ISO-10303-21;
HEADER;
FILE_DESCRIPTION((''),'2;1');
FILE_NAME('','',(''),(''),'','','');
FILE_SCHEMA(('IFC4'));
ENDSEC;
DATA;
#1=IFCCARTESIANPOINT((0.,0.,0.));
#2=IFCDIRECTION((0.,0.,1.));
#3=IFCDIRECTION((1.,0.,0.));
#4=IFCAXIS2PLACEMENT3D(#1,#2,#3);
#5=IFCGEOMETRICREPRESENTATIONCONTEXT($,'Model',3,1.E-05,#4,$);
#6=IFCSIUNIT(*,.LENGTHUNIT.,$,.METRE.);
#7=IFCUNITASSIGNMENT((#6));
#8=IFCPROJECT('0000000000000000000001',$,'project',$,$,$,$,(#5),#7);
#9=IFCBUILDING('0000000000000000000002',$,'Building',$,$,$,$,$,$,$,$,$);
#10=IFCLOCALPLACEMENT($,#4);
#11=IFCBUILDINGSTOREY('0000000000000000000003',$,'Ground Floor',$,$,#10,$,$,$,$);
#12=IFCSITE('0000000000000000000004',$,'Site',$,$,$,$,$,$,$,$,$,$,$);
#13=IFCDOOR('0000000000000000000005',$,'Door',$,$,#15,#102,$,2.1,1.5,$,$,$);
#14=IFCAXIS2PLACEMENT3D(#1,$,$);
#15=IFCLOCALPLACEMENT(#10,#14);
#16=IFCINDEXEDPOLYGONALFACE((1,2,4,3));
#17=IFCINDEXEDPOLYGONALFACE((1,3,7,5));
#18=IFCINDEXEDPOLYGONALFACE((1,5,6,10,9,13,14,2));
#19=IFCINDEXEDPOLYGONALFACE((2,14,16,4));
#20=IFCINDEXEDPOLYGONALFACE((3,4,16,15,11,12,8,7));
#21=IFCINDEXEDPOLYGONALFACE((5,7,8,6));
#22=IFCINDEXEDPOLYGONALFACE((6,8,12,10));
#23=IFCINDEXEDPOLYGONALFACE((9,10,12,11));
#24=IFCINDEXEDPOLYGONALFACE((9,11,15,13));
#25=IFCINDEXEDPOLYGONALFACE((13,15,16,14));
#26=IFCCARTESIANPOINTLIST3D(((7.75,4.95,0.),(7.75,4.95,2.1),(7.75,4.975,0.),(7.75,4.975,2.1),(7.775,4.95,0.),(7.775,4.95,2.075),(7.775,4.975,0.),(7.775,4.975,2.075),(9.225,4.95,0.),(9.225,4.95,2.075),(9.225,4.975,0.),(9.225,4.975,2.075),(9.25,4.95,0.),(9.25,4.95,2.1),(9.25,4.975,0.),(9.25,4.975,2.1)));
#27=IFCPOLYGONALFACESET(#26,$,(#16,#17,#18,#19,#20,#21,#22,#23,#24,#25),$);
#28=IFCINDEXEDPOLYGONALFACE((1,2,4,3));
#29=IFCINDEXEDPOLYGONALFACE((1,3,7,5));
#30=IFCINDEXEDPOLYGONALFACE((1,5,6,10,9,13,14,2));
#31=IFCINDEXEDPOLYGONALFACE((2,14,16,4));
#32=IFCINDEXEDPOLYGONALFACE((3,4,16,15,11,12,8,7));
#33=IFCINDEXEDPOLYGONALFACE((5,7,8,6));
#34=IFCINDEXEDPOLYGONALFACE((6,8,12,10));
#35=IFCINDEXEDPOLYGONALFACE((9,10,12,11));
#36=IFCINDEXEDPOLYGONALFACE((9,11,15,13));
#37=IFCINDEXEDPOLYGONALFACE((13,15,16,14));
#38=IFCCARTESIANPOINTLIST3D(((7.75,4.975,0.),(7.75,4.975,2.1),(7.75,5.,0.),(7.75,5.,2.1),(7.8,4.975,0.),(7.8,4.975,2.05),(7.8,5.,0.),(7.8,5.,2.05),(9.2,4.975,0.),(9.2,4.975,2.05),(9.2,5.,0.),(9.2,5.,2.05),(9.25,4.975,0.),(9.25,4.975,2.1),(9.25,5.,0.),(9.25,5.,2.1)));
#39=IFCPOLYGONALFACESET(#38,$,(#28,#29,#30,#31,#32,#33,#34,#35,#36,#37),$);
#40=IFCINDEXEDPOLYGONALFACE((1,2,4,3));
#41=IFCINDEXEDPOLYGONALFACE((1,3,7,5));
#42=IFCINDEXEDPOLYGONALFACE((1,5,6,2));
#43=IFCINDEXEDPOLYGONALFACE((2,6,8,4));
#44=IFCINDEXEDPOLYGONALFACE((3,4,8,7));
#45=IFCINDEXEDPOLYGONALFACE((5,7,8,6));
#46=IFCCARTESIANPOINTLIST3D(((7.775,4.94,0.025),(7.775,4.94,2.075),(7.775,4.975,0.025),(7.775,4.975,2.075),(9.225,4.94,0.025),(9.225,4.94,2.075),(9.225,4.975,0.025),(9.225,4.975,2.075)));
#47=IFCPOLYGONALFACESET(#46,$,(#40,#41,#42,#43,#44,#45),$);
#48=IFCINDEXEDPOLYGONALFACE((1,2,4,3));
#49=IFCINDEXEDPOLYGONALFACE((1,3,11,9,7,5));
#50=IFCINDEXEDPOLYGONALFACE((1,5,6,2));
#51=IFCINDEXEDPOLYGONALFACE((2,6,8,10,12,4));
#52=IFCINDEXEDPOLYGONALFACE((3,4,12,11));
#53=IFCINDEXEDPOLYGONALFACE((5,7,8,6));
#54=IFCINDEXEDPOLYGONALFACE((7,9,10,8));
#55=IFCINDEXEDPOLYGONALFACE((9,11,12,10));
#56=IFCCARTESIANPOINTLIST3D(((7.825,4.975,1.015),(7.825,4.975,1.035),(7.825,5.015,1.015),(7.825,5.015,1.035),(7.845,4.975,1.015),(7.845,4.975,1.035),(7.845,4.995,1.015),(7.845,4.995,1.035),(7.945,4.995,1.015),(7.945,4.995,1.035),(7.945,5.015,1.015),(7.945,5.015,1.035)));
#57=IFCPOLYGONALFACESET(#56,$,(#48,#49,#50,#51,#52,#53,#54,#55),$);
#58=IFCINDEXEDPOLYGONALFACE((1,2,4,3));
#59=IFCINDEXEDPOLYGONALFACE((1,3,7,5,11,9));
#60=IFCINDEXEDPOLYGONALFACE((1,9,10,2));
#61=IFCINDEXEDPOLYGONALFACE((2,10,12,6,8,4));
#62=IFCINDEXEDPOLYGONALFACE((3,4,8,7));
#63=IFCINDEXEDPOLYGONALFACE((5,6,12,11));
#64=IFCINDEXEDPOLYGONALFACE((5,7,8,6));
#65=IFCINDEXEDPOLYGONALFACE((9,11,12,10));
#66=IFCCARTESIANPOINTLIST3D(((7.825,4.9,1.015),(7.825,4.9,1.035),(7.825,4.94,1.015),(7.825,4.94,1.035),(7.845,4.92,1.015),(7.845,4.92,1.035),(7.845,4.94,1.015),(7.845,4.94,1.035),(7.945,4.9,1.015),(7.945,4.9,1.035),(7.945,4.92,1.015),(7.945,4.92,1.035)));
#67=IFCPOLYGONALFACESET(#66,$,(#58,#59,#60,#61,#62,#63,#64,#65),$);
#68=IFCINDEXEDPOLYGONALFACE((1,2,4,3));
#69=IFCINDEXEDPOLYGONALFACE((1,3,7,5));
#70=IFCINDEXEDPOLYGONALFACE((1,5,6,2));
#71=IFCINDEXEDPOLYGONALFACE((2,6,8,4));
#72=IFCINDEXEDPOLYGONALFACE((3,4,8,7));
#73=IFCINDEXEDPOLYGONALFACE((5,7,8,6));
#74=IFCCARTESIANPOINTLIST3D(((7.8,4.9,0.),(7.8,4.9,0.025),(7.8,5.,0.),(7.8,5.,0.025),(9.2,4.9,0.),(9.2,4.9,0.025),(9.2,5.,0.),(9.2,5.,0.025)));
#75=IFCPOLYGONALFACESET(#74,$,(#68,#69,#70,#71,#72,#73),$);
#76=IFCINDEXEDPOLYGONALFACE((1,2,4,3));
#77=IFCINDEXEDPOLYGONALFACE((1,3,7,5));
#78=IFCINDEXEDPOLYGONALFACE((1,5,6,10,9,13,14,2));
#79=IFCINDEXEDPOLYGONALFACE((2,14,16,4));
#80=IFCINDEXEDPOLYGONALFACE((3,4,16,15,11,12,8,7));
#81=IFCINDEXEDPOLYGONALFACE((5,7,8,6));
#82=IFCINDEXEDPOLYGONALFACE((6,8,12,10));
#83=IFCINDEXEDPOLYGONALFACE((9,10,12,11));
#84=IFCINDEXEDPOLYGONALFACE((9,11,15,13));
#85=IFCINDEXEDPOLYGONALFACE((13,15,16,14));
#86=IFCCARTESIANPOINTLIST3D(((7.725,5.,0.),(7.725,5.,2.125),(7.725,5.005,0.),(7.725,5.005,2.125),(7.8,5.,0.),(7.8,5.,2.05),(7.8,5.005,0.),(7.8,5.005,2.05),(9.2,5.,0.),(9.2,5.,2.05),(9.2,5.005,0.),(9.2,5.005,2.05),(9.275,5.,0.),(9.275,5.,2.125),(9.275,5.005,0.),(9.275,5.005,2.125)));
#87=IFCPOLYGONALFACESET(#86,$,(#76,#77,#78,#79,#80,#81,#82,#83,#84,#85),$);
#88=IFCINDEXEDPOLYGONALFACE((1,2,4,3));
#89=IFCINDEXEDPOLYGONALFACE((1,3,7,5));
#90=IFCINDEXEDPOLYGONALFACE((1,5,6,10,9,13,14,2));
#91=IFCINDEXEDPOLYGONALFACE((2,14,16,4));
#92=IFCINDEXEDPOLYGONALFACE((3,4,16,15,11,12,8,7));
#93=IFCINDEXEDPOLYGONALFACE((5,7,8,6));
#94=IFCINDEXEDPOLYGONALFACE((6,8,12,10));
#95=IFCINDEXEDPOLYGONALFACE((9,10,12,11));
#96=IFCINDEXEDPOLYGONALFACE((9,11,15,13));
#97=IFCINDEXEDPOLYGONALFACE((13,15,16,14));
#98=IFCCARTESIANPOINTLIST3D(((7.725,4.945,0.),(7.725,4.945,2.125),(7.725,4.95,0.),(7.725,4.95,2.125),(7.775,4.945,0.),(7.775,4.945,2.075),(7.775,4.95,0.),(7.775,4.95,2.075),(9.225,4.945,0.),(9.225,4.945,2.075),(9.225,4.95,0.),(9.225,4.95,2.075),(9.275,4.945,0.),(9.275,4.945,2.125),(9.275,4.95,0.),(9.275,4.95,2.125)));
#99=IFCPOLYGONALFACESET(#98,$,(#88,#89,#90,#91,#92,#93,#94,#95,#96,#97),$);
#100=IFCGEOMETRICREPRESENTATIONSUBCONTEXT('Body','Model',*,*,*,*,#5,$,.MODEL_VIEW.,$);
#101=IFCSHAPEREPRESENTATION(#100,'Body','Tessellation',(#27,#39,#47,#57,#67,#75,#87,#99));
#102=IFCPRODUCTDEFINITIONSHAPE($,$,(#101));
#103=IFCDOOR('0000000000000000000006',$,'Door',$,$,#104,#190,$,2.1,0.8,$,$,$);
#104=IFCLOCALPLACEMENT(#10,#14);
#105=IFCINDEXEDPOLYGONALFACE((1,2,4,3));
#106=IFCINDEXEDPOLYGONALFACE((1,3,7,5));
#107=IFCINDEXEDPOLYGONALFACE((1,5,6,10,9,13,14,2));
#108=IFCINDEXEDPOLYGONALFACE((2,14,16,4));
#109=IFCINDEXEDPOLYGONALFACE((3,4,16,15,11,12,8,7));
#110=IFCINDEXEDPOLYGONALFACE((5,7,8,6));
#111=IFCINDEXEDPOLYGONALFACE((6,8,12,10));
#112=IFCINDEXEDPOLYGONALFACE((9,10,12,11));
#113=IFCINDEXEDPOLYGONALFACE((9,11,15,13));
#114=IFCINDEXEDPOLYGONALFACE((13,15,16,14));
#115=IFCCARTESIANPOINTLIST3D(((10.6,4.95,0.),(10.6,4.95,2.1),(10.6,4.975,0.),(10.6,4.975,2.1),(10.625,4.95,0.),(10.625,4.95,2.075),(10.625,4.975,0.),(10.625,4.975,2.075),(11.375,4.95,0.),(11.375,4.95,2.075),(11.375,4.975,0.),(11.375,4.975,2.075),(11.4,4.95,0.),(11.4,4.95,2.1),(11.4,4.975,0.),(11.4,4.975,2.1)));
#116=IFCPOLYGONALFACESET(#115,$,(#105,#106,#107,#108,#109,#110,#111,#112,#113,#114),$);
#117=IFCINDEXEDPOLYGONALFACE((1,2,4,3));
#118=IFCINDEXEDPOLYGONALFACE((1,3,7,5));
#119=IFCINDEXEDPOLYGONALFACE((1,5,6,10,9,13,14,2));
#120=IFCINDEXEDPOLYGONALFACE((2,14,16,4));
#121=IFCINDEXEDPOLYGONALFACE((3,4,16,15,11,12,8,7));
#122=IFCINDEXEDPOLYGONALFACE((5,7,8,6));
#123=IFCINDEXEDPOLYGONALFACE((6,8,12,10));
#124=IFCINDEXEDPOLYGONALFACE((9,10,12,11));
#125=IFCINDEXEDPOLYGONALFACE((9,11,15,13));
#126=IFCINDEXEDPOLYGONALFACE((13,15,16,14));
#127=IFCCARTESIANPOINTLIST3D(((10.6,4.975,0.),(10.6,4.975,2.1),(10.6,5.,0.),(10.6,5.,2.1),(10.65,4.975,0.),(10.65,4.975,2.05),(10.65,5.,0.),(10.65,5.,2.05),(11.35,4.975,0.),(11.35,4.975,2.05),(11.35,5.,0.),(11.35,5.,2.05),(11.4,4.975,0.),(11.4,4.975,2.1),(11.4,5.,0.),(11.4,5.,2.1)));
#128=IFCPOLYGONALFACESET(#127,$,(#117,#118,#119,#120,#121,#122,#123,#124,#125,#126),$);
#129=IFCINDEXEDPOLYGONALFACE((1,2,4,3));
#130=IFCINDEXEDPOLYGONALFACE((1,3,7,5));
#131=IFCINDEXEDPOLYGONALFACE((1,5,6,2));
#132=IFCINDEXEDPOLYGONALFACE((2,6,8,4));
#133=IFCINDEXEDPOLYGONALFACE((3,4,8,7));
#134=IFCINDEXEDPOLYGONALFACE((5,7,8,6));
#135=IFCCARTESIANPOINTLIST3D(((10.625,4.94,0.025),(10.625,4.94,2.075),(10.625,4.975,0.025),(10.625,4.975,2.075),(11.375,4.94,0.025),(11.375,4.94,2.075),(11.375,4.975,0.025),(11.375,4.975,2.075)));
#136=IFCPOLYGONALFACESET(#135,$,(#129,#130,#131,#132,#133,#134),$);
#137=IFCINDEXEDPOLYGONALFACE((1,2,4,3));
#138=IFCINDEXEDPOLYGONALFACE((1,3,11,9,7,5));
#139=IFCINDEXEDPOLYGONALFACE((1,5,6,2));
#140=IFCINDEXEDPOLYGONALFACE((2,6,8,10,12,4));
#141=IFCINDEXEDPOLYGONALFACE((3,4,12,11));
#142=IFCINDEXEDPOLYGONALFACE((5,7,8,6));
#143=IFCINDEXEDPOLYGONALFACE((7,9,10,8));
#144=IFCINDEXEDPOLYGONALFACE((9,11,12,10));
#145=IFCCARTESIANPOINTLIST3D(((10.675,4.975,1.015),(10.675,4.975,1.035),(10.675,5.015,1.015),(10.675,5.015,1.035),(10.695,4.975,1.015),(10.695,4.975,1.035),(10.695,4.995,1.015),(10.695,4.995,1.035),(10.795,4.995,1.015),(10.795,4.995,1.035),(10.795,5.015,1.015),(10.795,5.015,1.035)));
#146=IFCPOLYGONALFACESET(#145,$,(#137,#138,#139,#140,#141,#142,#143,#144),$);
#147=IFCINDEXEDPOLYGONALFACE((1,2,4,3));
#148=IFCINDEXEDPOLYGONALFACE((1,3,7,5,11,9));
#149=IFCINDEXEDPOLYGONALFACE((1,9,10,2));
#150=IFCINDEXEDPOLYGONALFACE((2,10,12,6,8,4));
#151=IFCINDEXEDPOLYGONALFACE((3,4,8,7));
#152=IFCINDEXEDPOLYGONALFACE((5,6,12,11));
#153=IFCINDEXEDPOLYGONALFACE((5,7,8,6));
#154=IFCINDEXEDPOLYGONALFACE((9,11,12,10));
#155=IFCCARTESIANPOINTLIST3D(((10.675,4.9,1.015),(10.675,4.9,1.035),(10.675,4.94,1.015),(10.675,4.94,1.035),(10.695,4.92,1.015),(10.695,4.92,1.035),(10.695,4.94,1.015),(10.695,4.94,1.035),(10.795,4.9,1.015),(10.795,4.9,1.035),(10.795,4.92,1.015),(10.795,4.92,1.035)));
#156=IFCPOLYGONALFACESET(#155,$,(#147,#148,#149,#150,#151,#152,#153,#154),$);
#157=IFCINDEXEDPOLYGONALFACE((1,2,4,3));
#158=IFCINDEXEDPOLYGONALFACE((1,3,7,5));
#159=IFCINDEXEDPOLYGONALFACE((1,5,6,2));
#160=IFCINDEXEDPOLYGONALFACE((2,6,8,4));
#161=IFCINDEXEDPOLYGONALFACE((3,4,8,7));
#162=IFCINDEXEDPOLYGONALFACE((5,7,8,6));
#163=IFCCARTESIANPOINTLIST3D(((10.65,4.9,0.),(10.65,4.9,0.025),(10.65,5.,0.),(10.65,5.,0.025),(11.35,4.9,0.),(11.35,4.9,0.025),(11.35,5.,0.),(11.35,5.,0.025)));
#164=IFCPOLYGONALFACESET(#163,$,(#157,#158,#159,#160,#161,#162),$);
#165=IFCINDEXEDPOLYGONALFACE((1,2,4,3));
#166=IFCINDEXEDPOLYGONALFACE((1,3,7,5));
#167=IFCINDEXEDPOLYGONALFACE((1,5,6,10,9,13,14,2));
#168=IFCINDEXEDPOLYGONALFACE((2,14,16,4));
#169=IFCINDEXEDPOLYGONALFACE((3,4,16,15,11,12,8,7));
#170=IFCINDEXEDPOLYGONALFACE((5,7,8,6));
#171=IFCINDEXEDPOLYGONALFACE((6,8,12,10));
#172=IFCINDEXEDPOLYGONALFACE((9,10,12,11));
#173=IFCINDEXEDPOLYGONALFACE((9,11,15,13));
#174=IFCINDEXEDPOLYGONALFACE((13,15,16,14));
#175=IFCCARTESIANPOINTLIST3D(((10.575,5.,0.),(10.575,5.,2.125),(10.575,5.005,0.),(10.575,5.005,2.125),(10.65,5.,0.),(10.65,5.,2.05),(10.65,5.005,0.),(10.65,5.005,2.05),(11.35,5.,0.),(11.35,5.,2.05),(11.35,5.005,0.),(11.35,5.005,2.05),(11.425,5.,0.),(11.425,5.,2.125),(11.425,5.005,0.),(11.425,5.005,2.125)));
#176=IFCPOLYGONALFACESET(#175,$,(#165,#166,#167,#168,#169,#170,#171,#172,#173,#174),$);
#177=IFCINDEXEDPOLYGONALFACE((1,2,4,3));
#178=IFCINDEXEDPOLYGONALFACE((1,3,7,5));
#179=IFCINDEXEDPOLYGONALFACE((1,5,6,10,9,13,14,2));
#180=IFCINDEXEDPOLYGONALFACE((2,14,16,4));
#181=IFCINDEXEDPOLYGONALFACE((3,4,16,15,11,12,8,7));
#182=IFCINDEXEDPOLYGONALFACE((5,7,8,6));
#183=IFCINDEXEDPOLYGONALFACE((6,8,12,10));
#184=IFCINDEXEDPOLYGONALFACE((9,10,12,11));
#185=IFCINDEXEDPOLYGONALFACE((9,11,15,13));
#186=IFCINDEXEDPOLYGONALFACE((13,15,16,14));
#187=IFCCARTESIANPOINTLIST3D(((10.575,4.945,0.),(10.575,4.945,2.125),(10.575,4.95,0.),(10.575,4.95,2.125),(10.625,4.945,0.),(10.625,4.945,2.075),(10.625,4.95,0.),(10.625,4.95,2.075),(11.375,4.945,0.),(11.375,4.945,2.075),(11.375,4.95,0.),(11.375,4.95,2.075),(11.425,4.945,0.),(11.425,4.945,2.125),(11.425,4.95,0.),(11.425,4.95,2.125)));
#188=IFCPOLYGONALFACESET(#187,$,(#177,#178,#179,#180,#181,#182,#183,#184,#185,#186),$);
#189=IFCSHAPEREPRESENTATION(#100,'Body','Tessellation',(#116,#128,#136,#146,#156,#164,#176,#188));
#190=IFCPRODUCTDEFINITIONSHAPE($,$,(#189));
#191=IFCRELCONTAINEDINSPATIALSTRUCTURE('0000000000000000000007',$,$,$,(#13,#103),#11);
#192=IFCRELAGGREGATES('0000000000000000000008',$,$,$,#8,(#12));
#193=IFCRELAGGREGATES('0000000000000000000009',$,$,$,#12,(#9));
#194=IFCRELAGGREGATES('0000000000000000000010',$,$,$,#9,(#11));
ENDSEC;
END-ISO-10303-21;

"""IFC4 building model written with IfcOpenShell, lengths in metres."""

from ifc_helpers import new_model, si_unit, frame, origin_with_axes, place, context, subcontext, project, spatial, line, indexed_curve, outline, extrude, element, save


model = new_model("IFC4")

# Units and contexts
model_context = context("Model", 3, precision=1e-05, world=origin_with_axes())
body_context = subcontext(model_context, "Body", "Model", "MODEL_VIEW")
ifc_project = project(units=[si_unit("LENGTHUNIT", "METRE")], contexts=[model_context])

# Site, building, storey
site = spatial("IfcSite", under=ifc_project, Name="Site")
building = spatial("IfcBuilding", under=site, Name="Building")
storey_placement = place(None, origin_with_axes())
storey = spatial("IfcBuildingStorey", under=building, at=storey_placement, Name="Ground Floor")

# Doors
door_1_placement = place(storey_placement, frame((9.25, 5.0, 0.0), z_axis=(0.0, 0.0, 1.0), x_axis=(-1.0, 0.0, 0.0)))
element("IfcDoor", 1, at=door_1_placement, inside=storey, Name="Door", OverallHeight=2.1, OverallWidth=1.5, context=body_context, shape_type="SweptSolid", body=[
    extrude(outline(indexed_curve([(0.0, 0.0), (0.0, 2.1), (1.5, 2.1), (1.5, 0.0), (1.475, 0.0), (1.475, 2.075), (0.025, 2.075), (0.025, 0.0)], segments=[line(1, 2, 3, 4, 5, 6, 7, 8, 1)])), frame((0.0, 0.025, 0.0), z_axis=(0.0, -1.0, 0.0), x_axis=(1.0, 0.0, 0.0)), (0.0, 0.0, -1.0), 0.025),
    extrude(outline(indexed_curve([(0.0, 0.0), (0.0, 2.1), (1.5, 2.1), (1.5, 0.0), (1.45, 0.0), (1.45, 2.05), (0.05, 2.05), (0.05, 0.0)], segments=[line(1, 2, 3, 4, 5, 6, 7, 8, 1)])), frame((0.0, 0.0, 0.0), z_axis=(0.0, -1.0, 0.0), x_axis=(1.0, 0.0, 0.0)), (0.0, 0.0, -1.0), 0.025),
    extrude(outline(indexed_curve([(0.0, 0.0), (1.45, 0.0), (1.45, 0.035), (0.0, 0.035)], segments=[line(1, 2, 3, 4, 1)])), frame((0.025, 0.025, 0.025), z_axis=(0.0, 0.0, 1.0), x_axis=(1.0, 0.0, 0.0)), (0.0, 0.0, 1.0), 2.05),
    extrude(outline(indexed_curve([(0.0, 0.0), (0.0, -0.04), (-0.12, -0.04), (-0.12, -0.02), (-0.02, -0.02), (-0.02, 0.0)], segments=[line(1, 2, 3, 4, 5, 6, 1)])), frame((1.425, 0.025, 1.015), z_axis=(0.0, 0.0, 1.0), x_axis=(1.0, 0.0, 0.0)), (0.0, 0.0, 1.0), 0.02),
    extrude(outline(indexed_curve([(0.0, 0.0), (0.0, 0.04), (-0.12, 0.04), (-0.12, 0.02), (-0.02, 0.02), (-0.02, 0.0)], segments=[line(1, 2, 3, 4, 5, 6, 1)])), frame((1.425, 0.06, 1.015), z_axis=(0.0, 0.0, 1.0), x_axis=(1.0, 0.0, 0.0)), (0.0, 0.0, 1.0), 0.02),
    extrude(outline(indexed_curve([(0.0, 0.0), (1.4, 0.0), (1.4, 0.1), (0.0, 0.1)], segments=[line(1, 2, 3, 4, 1)])), frame((0.05, 0.0, 0.0), z_axis=(0.0, 0.0, 1.0), x_axis=(1.0, 0.0, 0.0)), (0.0, 0.0, 1.0), 0.025),
    extrude(outline(indexed_curve([(0.0, 0.0), (0.0, 2.125), (1.55, 2.125), (1.55, 0.0), (1.475, 0.0), (1.475, 2.05), (0.075, 2.05), (0.075, 0.0)], segments=[line(1, 2, 3, 4, 5, 6, 7, 8, 1)])), frame((-0.025, -0.005, 0.0), z_axis=(0.0, -1.0, 0.0), x_axis=(1.0, 0.0, 0.0)), (0.0, 0.0, -1.0), 0.005),
    extrude(outline(indexed_curve([(0.0, 0.0), (0.0, 2.125), (1.55, 2.125), (1.55, 0.0), (1.5, 0.0), (1.5, 2.075), (0.05, 2.075), (0.05, 0.0)], segments=[line(1, 2, 3, 4, 5, 6, 7, 8, 1)])), frame((-0.025, 0.05, 0.0), z_axis=(0.0, -1.0, 0.0), x_axis=(1.0, 0.0, 0.0)), (0.0, 0.0, -1.0), 0.005),
])
door_2_placement = place(storey_placement, frame((11.4, 5.0, 0.0), z_axis=(0.0, 0.0, 1.0), x_axis=(-1.0, 0.0, 0.0)))
element("IfcDoor", 2, at=door_2_placement, inside=storey, Name="Door", OverallHeight=2.1, OverallWidth=0.8, context=body_context, shape_type="SweptSolid", body=[
    extrude(outline(indexed_curve([(0.0, 0.0), (0.0, 2.1), (0.8, 2.1), (0.8, 0.0), (0.775, 0.0), (0.775, 2.075), (0.025, 2.075), (0.025, 0.0)], segments=[line(1, 2, 3, 4, 5, 6, 7, 8, 1)])), frame((0.0, 0.025, 0.0), z_axis=(0.0, -1.0, 0.0), x_axis=(1.0, 0.0, 0.0)), (0.0, 0.0, -1.0), 0.025),
    extrude(outline(indexed_curve([(0.0, 0.0), (0.0, 2.1), (0.8, 2.1), (0.8, 0.0), (0.75, 0.0), (0.75, 2.05), (0.05, 2.05), (0.05, 0.0)], segments=[line(1, 2, 3, 4, 5, 6, 7, 8, 1)])), frame((0.0, 0.0, 0.0), z_axis=(0.0, -1.0, 0.0), x_axis=(1.0, 0.0, 0.0)), (0.0, 0.0, -1.0), 0.025),
    extrude(outline(indexed_curve([(0.0, 0.0), (0.75, 0.0), (0.75, 0.035), (0.0, 0.035)], segments=[line(1, 2, 3, 4, 1)])), frame((0.025, 0.025, 0.025), z_axis=(0.0, 0.0, 1.0), x_axis=(1.0, 0.0, 0.0)), (0.0, 0.0, 1.0), 2.05),
    extrude(outline(indexed_curve([(0.0, 0.0), (0.0, -0.04), (-0.12, -0.04), (-0.12, -0.02), (-0.02, -0.02), (-0.02, 0.0)], segments=[line(1, 2, 3, 4, 5, 6, 1)])), frame((0.725, 0.025, 1.015), z_axis=(0.0, 0.0, 1.0), x_axis=(1.0, 0.0, 0.0)), (0.0, 0.0, 1.0), 0.02),
    extrude(outline(indexed_curve([(0.0, 0.0), (0.0, 0.04), (-0.12, 0.04), (-0.12, 0.02), (-0.02, 0.02), (-0.02, 0.0)], segments=[line(1, 2, 3, 4, 5, 6, 1)])), frame((0.725, 0.06, 1.015), z_axis=(0.0, 0.0, 1.0), x_axis=(1.0, 0.0, 0.0)), (0.0, 0.0, 1.0), 0.02),
    extrude(outline(indexed_curve([(0.0, 0.0), (0.7, 0.0), (0.7, 0.1), (0.0, 0.1)], segments=[line(1, 2, 3, 4, 1)])), frame((0.05, 0.0, 0.0), z_axis=(0.0, 0.0, 1.0), x_axis=(1.0, 0.0, 0.0)), (0.0, 0.0, 1.0), 0.025),
    extrude(outline(indexed_curve([(0.0, 0.0), (0.0, 2.125), (0.85, 2.125), (0.85, 0.0), (0.775, 0.0), (0.775, 2.05), (0.075, 2.05), (0.075, 0.0)], segments=[line(1, 2, 3, 4, 5, 6, 7, 8, 1)])), frame((-0.025, -0.005, 0.0), z_axis=(0.0, -1.0, 0.0), x_axis=(1.0, 0.0, 0.0)), (0.0, 0.0, -1.0), 0.005),
    extrude(outline(indexed_curve([(0.0, 0.0), (0.0, 2.125), (0.85, 2.125), (0.85, 0.0), (0.8, 0.0), (0.8, 2.075), (0.05, 2.075), (0.05, 0.0)], segments=[line(1, 2, 3, 4, 5, 6, 7, 8, 1)])), frame((-0.025, 0.05, 0.0), z_axis=(0.0, -1.0, 0.0), x_axis=(1.0, 0.0, 0.0)), (0.0, 0.0, -1.0), 0.005),
])

save(model, "model.ifc")
